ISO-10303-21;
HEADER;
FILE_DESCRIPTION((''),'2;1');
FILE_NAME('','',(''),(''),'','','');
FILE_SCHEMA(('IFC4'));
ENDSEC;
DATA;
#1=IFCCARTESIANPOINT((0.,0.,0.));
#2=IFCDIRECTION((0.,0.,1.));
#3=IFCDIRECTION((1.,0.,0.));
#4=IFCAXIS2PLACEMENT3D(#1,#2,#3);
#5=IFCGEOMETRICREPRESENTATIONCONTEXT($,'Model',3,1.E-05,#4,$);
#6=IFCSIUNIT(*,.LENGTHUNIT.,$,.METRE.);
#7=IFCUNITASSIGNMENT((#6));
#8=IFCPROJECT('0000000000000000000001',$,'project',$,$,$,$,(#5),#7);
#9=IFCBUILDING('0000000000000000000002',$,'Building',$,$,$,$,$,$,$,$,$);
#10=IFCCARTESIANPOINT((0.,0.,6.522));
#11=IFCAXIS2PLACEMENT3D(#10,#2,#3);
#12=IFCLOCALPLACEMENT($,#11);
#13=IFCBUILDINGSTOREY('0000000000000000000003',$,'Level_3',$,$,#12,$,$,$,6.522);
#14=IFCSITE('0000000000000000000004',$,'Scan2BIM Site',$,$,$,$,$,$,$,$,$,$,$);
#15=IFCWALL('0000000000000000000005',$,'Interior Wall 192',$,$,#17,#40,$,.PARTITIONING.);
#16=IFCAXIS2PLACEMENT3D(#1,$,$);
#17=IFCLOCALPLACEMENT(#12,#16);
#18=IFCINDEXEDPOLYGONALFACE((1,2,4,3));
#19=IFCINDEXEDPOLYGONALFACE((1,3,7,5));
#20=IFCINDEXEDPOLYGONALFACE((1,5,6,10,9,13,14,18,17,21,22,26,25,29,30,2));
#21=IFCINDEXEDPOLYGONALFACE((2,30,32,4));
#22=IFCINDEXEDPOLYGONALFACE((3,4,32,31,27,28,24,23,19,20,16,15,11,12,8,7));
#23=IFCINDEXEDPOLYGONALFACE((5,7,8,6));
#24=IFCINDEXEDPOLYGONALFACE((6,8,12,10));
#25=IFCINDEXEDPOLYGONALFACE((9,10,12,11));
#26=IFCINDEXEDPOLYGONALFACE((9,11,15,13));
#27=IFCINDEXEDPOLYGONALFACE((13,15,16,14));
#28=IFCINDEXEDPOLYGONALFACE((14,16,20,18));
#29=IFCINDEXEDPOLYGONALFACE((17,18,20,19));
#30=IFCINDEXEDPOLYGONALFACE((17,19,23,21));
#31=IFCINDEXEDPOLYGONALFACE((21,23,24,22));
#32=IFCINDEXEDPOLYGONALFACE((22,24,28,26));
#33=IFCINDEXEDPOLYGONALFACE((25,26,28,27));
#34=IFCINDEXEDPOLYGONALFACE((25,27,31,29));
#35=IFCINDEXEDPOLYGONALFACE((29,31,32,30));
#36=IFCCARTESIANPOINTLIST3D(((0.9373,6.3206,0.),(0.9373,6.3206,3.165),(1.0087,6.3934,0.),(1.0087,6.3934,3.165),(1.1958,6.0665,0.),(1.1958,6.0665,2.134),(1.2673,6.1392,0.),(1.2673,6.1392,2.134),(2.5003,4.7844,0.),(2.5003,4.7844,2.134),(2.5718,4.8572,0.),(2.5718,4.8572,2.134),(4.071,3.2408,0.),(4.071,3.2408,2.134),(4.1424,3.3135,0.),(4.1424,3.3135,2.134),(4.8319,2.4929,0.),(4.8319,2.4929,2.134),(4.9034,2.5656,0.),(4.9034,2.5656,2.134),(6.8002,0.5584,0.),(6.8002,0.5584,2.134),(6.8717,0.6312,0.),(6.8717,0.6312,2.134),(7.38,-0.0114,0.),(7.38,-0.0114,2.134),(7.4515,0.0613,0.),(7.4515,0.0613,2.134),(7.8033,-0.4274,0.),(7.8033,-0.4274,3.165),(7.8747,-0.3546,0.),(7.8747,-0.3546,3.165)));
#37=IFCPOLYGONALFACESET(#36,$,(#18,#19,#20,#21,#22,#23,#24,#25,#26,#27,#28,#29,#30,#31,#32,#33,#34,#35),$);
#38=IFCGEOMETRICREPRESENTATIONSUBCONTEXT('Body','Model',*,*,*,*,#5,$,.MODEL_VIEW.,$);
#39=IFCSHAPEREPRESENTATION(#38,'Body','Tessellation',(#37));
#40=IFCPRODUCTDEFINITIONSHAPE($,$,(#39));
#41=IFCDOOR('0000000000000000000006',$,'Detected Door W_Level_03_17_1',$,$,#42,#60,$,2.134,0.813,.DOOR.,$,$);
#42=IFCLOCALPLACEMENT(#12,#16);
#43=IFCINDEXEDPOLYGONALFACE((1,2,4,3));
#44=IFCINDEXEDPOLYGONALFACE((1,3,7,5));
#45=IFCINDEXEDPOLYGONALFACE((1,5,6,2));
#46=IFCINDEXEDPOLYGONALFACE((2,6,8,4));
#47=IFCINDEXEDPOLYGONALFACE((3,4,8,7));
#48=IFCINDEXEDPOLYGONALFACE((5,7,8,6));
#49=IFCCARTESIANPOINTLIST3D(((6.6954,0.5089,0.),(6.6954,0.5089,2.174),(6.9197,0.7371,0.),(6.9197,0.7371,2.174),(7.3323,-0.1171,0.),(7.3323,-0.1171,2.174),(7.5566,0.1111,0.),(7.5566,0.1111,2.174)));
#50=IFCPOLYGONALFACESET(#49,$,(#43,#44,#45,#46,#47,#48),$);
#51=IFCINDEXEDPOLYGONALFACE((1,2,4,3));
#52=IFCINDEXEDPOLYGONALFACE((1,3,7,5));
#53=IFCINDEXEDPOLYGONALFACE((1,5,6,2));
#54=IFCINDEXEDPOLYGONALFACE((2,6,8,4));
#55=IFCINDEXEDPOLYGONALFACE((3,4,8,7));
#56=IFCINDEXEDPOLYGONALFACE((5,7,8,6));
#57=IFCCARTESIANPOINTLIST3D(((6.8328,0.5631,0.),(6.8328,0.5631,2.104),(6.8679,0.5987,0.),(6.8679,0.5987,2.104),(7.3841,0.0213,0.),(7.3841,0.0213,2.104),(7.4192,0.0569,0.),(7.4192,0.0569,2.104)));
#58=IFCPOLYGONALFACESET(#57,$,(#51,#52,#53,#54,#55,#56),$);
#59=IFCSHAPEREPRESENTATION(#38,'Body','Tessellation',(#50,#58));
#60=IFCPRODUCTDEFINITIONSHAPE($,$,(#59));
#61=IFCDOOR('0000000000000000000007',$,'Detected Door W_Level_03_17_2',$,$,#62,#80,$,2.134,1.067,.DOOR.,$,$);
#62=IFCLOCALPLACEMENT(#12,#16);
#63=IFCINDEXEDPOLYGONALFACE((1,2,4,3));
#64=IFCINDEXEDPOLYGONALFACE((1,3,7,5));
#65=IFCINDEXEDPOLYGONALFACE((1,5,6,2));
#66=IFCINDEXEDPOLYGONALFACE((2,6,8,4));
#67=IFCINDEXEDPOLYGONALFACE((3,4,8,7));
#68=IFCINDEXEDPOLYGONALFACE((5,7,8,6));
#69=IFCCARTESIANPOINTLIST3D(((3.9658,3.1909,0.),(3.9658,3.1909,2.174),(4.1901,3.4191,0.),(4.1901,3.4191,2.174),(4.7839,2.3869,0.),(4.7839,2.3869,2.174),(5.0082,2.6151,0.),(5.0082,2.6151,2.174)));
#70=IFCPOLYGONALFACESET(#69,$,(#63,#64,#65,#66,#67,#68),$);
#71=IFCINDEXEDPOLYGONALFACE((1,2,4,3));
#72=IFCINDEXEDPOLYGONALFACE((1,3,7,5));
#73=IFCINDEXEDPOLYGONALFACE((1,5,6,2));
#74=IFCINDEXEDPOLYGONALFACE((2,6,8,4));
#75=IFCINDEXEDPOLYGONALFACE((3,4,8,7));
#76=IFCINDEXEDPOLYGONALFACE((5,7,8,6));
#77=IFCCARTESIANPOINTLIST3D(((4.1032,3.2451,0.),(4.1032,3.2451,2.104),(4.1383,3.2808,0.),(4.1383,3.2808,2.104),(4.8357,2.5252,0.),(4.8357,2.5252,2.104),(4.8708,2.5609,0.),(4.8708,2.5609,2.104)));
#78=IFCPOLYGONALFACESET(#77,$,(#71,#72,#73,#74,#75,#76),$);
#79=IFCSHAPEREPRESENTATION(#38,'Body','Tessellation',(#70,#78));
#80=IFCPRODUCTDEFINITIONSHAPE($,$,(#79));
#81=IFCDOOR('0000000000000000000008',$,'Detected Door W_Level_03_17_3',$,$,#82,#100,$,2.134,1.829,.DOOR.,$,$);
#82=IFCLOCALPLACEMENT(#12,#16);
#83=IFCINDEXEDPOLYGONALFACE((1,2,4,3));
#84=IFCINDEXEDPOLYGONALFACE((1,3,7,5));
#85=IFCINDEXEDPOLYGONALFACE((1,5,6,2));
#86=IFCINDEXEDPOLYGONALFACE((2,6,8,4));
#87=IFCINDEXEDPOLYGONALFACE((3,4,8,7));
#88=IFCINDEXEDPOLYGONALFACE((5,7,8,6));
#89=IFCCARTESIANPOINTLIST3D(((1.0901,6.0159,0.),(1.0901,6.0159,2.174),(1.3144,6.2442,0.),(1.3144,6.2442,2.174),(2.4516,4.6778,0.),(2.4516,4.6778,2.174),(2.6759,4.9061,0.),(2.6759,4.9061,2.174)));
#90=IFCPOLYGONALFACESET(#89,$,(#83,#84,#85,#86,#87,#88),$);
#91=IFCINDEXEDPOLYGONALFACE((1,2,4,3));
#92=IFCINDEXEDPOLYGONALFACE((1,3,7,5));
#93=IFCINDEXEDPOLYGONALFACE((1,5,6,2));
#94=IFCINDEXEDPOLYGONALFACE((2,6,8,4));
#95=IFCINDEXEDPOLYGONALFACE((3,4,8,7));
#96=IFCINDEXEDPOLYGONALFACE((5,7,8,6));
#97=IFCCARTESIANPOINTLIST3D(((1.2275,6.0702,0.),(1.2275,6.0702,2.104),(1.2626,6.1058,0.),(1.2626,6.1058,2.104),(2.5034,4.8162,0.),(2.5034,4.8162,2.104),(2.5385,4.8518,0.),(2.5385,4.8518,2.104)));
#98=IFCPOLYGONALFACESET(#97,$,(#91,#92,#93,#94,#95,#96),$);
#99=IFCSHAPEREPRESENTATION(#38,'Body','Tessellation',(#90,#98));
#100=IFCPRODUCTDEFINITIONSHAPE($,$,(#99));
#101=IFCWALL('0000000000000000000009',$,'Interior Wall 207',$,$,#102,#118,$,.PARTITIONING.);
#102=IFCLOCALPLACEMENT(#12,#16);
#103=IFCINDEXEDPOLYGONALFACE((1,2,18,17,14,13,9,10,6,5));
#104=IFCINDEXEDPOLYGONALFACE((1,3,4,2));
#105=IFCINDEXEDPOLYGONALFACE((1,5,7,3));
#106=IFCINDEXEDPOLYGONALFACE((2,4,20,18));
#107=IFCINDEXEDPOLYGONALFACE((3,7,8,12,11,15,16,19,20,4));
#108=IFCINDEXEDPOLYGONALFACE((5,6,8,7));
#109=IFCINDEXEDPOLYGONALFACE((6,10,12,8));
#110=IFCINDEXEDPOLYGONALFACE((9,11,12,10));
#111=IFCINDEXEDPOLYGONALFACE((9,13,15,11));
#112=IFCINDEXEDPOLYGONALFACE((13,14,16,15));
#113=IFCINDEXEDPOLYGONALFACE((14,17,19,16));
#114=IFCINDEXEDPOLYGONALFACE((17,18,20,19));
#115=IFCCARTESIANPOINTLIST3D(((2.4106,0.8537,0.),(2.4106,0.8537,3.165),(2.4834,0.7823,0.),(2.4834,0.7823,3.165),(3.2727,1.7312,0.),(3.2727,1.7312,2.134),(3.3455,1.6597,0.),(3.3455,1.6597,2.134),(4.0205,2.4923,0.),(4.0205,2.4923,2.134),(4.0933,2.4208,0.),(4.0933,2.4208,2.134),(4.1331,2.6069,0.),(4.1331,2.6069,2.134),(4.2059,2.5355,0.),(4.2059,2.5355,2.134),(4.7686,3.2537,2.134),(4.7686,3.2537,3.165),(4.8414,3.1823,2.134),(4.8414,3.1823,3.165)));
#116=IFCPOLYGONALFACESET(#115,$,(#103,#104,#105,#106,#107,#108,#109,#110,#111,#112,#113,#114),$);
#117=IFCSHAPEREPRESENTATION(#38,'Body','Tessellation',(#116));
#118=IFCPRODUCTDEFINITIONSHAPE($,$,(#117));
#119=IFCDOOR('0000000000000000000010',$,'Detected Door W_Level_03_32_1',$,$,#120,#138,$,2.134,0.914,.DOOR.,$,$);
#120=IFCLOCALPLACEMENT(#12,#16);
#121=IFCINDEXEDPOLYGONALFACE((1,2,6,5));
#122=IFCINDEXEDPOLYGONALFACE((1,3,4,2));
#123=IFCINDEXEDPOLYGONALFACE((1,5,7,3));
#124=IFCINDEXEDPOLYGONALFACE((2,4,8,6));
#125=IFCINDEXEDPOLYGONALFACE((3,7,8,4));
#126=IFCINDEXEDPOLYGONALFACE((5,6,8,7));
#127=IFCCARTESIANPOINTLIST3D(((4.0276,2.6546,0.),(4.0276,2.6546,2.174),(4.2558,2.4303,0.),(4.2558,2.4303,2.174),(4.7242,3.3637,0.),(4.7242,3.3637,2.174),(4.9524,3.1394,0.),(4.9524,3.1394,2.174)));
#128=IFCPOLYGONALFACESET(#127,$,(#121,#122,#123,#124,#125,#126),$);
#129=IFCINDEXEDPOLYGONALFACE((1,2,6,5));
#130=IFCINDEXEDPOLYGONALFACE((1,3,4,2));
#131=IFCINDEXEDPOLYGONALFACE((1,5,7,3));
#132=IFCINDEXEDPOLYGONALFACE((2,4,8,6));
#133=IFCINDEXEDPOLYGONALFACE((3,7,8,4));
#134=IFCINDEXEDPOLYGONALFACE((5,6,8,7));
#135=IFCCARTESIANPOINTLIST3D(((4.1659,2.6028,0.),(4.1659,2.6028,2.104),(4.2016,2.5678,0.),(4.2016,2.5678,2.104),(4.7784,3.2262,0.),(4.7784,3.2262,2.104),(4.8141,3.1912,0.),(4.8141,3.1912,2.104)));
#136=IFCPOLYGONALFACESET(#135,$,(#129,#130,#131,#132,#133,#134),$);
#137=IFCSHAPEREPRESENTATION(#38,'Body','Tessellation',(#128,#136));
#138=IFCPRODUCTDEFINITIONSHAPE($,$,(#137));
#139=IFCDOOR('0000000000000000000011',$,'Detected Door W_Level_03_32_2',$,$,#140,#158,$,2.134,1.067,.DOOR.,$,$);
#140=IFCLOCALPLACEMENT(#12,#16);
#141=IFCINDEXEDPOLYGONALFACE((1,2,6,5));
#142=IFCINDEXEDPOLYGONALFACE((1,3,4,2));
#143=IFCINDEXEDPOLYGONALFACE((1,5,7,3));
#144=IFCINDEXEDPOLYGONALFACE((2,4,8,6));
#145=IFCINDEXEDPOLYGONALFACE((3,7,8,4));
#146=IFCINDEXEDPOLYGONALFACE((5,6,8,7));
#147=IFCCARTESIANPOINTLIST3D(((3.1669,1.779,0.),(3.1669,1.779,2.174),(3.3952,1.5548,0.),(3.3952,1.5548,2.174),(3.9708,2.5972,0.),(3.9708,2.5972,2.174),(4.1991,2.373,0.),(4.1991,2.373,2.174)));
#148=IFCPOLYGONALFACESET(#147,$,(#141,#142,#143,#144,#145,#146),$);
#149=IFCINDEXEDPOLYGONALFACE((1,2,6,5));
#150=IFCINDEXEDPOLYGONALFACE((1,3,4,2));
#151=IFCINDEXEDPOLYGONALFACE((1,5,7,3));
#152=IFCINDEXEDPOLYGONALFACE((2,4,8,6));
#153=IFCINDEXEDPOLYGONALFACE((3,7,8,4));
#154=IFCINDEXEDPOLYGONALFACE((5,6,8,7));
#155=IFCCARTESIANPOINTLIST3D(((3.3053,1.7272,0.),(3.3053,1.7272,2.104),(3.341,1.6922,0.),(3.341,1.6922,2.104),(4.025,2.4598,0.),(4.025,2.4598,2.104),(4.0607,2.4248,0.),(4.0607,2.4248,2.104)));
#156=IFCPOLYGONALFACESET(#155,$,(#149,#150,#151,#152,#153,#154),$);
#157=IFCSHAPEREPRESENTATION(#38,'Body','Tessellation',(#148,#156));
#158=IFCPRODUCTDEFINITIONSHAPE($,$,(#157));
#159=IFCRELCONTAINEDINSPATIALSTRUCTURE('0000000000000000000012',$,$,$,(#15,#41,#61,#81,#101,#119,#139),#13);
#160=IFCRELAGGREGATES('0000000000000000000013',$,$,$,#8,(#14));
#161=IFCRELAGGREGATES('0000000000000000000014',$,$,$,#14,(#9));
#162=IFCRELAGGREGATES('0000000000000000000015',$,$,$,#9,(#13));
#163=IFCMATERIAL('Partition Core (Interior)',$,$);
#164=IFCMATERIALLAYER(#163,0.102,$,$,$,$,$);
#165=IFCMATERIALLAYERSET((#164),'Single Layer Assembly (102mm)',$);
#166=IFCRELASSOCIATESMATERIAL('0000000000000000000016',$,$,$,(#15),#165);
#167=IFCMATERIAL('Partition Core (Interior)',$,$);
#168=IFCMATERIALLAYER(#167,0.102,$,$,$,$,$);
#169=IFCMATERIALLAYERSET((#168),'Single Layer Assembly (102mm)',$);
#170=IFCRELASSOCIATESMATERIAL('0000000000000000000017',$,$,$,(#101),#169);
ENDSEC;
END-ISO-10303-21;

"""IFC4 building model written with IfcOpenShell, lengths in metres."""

from ifc_helpers import new_model, si_unit, frame, origin, origin_with_axes, place, context, subcontext, project, spatial, rectangle, extrude, material, layer, layer_set, element, fill, save


model = new_model("IFC4")

# Units and contexts
model_context = context("Model", 3, precision=1e-05, world=origin_with_axes())
body_context = subcontext(model_context, "Body", "Model", "MODEL_VIEW")
ifc_project = project(units=[si_unit("LENGTHUNIT", "METRE")], contexts=[model_context])

# Site, building, storey
site = spatial("IfcSite", under=ifc_project, Name="Scan2BIM Site")
building = spatial("IfcBuilding", under=site, Name="Building")
storey_placement = place(None, frame((0.0, 0.0, 6.522), z_axis=(0.0, 0.0, 1.0), x_axis=(1.0, 0.0, 0.0)))
storey = spatial("IfcBuildingStorey", under=building, at=storey_placement, Name="Level_3", Elevation=6.522)

# Walls, openings, doors
ifc_material_1 = material(Name="Partition Core (Interior)")
ifc_layer_1 = layer(ifc_material_1, 0.102)
ifc_layer_set_1 = layer_set([ifc_layer_1], Name="Single Layer Assembly (102mm)")
wall_1_placement = place(storey_placement, frame((4.406, 2.983, 0.0), z_axis=(0.0, 0.0, 1.0), x_axis=(-0.713209, 0.700952, 0.0)))
wall_1 = element("IfcWall", 1, at=wall_1_placement, inside=storey, material=ifc_layer_set_1, Name="Interior Wall 192", PredefinedType="PARTITIONING", context=body_context, shape_type="SweptSolid", body=[
    extrude(rectangle(XDim=9.6269, YDim=0.102), origin(), (0.0, 0.0, 1.0), 3.165),
])
opening_1_placement = place(None, frame((7.126, 0.31, 6.522), z_axis=(0.0, 0.0, 1.0), x_axis=(-0.713209, 0.700952, 0.0)))
opening_1 = element("IfcOpeningElement", 2, at=opening_1_placement, cuts=wall_1, PredefinedType="OPENING", context=body_context, shape_type="SweptSolid", body=[
    extrude(rectangle(XDim=0.813, YDim=0.202), origin(), (0.0, 0.0, 1.0), 2.134),
])
opening_2_placement = place(None, frame((4.487, 2.903, 6.522), z_axis=(0.0, 0.0, 1.0), x_axis=(-0.713209, 0.700952, 0.0)))
opening_2 = element("IfcOpeningElement", 3, at=opening_2_placement, cuts=wall_1, PredefinedType="OPENING", context=body_context, shape_type="SweptSolid", body=[
    extrude(rectangle(XDim=1.067, YDim=0.202), origin(), (0.0, 0.0, 1.0), 2.134),
])
opening_3_placement = place(None, frame((1.883, 5.461, 6.522), z_axis=(0.0, 0.0, 1.0), x_axis=(-0.713209, 0.700952, 0.0)))
opening_3 = element("IfcOpeningElement", 4, at=opening_3_placement, cuts=wall_1, PredefinedType="OPENING", context=body_context, shape_type="SweptSolid", body=[
    extrude(rectangle(XDim=1.829, YDim=0.202), origin(), (0.0, 0.0, 1.0), 2.134),
])
door_1_placement = place(opening_1_placement, frame((0.0, 0.0, 0.0), z_axis=(0.0, 0.0, 1.0), x_axis=(1.0, 0.0, 0.0)))
door_1 = element("IfcDoor", 5, at=door_1_placement, inside=storey, Name="Detected Door W_Level_03_17_1", OverallHeight=2.134, OverallWidth=0.813, PredefinedType="DOOR", context=body_context, shape_type="SweptSolid", body=[
    extrude(rectangle(XDim=0.893, YDim=0.32), origin(), (0.0, 0.0, 1.0), 2.174),
    extrude(rectangle(XDim=0.773, YDim=0.05), origin(), (0.0, 0.0, 1.0), 2.104),
])
fill(opening_1, door_1)
door_2_placement = place(opening_2_placement, frame((0.0, 0.0, 0.0), z_axis=(0.0, 0.0, 1.0), x_axis=(1.0, 0.0, 0.0)))
door_2 = element("IfcDoor", 6, at=door_2_placement, inside=storey, Name="Detected Door W_Level_03_17_2", OverallHeight=2.134, OverallWidth=1.067, PredefinedType="DOOR", context=body_context, shape_type="SweptSolid", body=[
    extrude(rectangle(XDim=1.147, YDim=0.32), origin(), (0.0, 0.0, 1.0), 2.174),
    extrude(rectangle(XDim=1.027, YDim=0.05), origin(), (0.0, 0.0, 1.0), 2.104),
])
fill(opening_2, door_2)
door_3_placement = place(opening_3_placement, frame((0.0, 0.0, 0.0), z_axis=(0.0, 0.0, 1.0), x_axis=(1.0, 0.0, 0.0)))
door_3 = element("IfcDoor", 7, at=door_3_placement, inside=storey, Name="Detected Door W_Level_03_17_3", OverallHeight=2.134, OverallWidth=1.829, PredefinedType="DOOR", context=body_context, shape_type="SweptSolid", body=[
    extrude(rectangle(XDim=1.909, YDim=0.32), origin(), (0.0, 0.0, 1.0), 2.174),
    extrude(rectangle(XDim=1.789, YDim=0.05), origin(), (0.0, 0.0, 1.0), 2.104),
])
fill(opening_3, door_3)
ifc_material_2 = material(Name="Partition Core (Interior)")
ifc_layer_2 = layer(ifc_material_2, 0.102)
ifc_layer_set_2 = layer_set([ifc_layer_2], Name="Single Layer Assembly (102mm)")
wall_2_placement = place(storey_placement, frame((3.626, 2.018, 0.0), z_axis=(0.0, 0.0, 1.0), x_axis=(-0.700838, -0.713321, 0.0)))
wall_2 = element("IfcWall", 8, at=wall_2_placement, inside=storey, material=ifc_layer_set_2, Name="Interior Wall 207", PredefinedType="PARTITIONING", context=body_context, shape_type="SweptSolid", body=[
    extrude(rectangle(XDim=3.3645, YDim=0.102), origin(), (0.0, 0.0, 1.0), 3.165),
])
opening_4_placement = place(None, frame((4.49, 2.897, 6.522), z_axis=(0.0, 0.0, 1.0), x_axis=(-0.700838, -0.713321, 0.0)))
opening_4 = element("IfcOpeningElement", 9, at=opening_4_placement, cuts=wall_2, PredefinedType="OPENING", context=body_context, shape_type="SweptSolid", body=[
    extrude(rectangle(XDim=0.914, YDim=0.202), origin(), (0.0, 0.0, 1.0), 2.134),
])
opening_5_placement = place(None, frame((3.683, 2.076, 6.522), z_axis=(0.0, 0.0, 1.0), x_axis=(-0.700838, -0.713321, 0.0)))
opening_5 = element("IfcOpeningElement", 10, at=opening_5_placement, cuts=wall_2, PredefinedType="OPENING", context=body_context, shape_type="SweptSolid", body=[
    extrude(rectangle(XDim=1.067, YDim=0.202), origin(), (0.0, 0.0, 1.0), 2.134),
])
door_4_placement = place(opening_4_placement, frame((0.0, 0.0, 0.0), z_axis=(0.0, 0.0, 1.0), x_axis=(1.0, 0.0, 0.0)))
door_4 = element("IfcDoor", 11, at=door_4_placement, inside=storey, Name="Detected Door W_Level_03_32_1", OverallHeight=2.134, OverallWidth=0.914, PredefinedType="DOOR", context=body_context, shape_type="SweptSolid", body=[
    extrude(rectangle(XDim=0.994, YDim=0.32), origin(), (0.0, 0.0, 1.0), 2.174),
    extrude(rectangle(XDim=0.874, YDim=0.05), origin(), (0.0, 0.0, 1.0), 2.104),
])
fill(opening_4, door_4)
door_5_placement = place(opening_5_placement, frame((0.0, 0.0, 0.0), z_axis=(0.0, 0.0, 1.0), x_axis=(1.0, 0.0, 0.0)))
door_5 = element("IfcDoor", 12, at=door_5_placement, inside=storey, Name="Detected Door W_Level_03_32_2", OverallHeight=2.134, OverallWidth=1.067, PredefinedType="DOOR", context=body_context, shape_type="SweptSolid", body=[
    extrude(rectangle(XDim=1.147, YDim=0.32), origin(), (0.0, 0.0, 1.0), 2.174),
    extrude(rectangle(XDim=1.027, YDim=0.05), origin(), (0.0, 0.0, 1.0), 2.104),
])
fill(opening_5, door_5)

save(model, "model.ifc")
